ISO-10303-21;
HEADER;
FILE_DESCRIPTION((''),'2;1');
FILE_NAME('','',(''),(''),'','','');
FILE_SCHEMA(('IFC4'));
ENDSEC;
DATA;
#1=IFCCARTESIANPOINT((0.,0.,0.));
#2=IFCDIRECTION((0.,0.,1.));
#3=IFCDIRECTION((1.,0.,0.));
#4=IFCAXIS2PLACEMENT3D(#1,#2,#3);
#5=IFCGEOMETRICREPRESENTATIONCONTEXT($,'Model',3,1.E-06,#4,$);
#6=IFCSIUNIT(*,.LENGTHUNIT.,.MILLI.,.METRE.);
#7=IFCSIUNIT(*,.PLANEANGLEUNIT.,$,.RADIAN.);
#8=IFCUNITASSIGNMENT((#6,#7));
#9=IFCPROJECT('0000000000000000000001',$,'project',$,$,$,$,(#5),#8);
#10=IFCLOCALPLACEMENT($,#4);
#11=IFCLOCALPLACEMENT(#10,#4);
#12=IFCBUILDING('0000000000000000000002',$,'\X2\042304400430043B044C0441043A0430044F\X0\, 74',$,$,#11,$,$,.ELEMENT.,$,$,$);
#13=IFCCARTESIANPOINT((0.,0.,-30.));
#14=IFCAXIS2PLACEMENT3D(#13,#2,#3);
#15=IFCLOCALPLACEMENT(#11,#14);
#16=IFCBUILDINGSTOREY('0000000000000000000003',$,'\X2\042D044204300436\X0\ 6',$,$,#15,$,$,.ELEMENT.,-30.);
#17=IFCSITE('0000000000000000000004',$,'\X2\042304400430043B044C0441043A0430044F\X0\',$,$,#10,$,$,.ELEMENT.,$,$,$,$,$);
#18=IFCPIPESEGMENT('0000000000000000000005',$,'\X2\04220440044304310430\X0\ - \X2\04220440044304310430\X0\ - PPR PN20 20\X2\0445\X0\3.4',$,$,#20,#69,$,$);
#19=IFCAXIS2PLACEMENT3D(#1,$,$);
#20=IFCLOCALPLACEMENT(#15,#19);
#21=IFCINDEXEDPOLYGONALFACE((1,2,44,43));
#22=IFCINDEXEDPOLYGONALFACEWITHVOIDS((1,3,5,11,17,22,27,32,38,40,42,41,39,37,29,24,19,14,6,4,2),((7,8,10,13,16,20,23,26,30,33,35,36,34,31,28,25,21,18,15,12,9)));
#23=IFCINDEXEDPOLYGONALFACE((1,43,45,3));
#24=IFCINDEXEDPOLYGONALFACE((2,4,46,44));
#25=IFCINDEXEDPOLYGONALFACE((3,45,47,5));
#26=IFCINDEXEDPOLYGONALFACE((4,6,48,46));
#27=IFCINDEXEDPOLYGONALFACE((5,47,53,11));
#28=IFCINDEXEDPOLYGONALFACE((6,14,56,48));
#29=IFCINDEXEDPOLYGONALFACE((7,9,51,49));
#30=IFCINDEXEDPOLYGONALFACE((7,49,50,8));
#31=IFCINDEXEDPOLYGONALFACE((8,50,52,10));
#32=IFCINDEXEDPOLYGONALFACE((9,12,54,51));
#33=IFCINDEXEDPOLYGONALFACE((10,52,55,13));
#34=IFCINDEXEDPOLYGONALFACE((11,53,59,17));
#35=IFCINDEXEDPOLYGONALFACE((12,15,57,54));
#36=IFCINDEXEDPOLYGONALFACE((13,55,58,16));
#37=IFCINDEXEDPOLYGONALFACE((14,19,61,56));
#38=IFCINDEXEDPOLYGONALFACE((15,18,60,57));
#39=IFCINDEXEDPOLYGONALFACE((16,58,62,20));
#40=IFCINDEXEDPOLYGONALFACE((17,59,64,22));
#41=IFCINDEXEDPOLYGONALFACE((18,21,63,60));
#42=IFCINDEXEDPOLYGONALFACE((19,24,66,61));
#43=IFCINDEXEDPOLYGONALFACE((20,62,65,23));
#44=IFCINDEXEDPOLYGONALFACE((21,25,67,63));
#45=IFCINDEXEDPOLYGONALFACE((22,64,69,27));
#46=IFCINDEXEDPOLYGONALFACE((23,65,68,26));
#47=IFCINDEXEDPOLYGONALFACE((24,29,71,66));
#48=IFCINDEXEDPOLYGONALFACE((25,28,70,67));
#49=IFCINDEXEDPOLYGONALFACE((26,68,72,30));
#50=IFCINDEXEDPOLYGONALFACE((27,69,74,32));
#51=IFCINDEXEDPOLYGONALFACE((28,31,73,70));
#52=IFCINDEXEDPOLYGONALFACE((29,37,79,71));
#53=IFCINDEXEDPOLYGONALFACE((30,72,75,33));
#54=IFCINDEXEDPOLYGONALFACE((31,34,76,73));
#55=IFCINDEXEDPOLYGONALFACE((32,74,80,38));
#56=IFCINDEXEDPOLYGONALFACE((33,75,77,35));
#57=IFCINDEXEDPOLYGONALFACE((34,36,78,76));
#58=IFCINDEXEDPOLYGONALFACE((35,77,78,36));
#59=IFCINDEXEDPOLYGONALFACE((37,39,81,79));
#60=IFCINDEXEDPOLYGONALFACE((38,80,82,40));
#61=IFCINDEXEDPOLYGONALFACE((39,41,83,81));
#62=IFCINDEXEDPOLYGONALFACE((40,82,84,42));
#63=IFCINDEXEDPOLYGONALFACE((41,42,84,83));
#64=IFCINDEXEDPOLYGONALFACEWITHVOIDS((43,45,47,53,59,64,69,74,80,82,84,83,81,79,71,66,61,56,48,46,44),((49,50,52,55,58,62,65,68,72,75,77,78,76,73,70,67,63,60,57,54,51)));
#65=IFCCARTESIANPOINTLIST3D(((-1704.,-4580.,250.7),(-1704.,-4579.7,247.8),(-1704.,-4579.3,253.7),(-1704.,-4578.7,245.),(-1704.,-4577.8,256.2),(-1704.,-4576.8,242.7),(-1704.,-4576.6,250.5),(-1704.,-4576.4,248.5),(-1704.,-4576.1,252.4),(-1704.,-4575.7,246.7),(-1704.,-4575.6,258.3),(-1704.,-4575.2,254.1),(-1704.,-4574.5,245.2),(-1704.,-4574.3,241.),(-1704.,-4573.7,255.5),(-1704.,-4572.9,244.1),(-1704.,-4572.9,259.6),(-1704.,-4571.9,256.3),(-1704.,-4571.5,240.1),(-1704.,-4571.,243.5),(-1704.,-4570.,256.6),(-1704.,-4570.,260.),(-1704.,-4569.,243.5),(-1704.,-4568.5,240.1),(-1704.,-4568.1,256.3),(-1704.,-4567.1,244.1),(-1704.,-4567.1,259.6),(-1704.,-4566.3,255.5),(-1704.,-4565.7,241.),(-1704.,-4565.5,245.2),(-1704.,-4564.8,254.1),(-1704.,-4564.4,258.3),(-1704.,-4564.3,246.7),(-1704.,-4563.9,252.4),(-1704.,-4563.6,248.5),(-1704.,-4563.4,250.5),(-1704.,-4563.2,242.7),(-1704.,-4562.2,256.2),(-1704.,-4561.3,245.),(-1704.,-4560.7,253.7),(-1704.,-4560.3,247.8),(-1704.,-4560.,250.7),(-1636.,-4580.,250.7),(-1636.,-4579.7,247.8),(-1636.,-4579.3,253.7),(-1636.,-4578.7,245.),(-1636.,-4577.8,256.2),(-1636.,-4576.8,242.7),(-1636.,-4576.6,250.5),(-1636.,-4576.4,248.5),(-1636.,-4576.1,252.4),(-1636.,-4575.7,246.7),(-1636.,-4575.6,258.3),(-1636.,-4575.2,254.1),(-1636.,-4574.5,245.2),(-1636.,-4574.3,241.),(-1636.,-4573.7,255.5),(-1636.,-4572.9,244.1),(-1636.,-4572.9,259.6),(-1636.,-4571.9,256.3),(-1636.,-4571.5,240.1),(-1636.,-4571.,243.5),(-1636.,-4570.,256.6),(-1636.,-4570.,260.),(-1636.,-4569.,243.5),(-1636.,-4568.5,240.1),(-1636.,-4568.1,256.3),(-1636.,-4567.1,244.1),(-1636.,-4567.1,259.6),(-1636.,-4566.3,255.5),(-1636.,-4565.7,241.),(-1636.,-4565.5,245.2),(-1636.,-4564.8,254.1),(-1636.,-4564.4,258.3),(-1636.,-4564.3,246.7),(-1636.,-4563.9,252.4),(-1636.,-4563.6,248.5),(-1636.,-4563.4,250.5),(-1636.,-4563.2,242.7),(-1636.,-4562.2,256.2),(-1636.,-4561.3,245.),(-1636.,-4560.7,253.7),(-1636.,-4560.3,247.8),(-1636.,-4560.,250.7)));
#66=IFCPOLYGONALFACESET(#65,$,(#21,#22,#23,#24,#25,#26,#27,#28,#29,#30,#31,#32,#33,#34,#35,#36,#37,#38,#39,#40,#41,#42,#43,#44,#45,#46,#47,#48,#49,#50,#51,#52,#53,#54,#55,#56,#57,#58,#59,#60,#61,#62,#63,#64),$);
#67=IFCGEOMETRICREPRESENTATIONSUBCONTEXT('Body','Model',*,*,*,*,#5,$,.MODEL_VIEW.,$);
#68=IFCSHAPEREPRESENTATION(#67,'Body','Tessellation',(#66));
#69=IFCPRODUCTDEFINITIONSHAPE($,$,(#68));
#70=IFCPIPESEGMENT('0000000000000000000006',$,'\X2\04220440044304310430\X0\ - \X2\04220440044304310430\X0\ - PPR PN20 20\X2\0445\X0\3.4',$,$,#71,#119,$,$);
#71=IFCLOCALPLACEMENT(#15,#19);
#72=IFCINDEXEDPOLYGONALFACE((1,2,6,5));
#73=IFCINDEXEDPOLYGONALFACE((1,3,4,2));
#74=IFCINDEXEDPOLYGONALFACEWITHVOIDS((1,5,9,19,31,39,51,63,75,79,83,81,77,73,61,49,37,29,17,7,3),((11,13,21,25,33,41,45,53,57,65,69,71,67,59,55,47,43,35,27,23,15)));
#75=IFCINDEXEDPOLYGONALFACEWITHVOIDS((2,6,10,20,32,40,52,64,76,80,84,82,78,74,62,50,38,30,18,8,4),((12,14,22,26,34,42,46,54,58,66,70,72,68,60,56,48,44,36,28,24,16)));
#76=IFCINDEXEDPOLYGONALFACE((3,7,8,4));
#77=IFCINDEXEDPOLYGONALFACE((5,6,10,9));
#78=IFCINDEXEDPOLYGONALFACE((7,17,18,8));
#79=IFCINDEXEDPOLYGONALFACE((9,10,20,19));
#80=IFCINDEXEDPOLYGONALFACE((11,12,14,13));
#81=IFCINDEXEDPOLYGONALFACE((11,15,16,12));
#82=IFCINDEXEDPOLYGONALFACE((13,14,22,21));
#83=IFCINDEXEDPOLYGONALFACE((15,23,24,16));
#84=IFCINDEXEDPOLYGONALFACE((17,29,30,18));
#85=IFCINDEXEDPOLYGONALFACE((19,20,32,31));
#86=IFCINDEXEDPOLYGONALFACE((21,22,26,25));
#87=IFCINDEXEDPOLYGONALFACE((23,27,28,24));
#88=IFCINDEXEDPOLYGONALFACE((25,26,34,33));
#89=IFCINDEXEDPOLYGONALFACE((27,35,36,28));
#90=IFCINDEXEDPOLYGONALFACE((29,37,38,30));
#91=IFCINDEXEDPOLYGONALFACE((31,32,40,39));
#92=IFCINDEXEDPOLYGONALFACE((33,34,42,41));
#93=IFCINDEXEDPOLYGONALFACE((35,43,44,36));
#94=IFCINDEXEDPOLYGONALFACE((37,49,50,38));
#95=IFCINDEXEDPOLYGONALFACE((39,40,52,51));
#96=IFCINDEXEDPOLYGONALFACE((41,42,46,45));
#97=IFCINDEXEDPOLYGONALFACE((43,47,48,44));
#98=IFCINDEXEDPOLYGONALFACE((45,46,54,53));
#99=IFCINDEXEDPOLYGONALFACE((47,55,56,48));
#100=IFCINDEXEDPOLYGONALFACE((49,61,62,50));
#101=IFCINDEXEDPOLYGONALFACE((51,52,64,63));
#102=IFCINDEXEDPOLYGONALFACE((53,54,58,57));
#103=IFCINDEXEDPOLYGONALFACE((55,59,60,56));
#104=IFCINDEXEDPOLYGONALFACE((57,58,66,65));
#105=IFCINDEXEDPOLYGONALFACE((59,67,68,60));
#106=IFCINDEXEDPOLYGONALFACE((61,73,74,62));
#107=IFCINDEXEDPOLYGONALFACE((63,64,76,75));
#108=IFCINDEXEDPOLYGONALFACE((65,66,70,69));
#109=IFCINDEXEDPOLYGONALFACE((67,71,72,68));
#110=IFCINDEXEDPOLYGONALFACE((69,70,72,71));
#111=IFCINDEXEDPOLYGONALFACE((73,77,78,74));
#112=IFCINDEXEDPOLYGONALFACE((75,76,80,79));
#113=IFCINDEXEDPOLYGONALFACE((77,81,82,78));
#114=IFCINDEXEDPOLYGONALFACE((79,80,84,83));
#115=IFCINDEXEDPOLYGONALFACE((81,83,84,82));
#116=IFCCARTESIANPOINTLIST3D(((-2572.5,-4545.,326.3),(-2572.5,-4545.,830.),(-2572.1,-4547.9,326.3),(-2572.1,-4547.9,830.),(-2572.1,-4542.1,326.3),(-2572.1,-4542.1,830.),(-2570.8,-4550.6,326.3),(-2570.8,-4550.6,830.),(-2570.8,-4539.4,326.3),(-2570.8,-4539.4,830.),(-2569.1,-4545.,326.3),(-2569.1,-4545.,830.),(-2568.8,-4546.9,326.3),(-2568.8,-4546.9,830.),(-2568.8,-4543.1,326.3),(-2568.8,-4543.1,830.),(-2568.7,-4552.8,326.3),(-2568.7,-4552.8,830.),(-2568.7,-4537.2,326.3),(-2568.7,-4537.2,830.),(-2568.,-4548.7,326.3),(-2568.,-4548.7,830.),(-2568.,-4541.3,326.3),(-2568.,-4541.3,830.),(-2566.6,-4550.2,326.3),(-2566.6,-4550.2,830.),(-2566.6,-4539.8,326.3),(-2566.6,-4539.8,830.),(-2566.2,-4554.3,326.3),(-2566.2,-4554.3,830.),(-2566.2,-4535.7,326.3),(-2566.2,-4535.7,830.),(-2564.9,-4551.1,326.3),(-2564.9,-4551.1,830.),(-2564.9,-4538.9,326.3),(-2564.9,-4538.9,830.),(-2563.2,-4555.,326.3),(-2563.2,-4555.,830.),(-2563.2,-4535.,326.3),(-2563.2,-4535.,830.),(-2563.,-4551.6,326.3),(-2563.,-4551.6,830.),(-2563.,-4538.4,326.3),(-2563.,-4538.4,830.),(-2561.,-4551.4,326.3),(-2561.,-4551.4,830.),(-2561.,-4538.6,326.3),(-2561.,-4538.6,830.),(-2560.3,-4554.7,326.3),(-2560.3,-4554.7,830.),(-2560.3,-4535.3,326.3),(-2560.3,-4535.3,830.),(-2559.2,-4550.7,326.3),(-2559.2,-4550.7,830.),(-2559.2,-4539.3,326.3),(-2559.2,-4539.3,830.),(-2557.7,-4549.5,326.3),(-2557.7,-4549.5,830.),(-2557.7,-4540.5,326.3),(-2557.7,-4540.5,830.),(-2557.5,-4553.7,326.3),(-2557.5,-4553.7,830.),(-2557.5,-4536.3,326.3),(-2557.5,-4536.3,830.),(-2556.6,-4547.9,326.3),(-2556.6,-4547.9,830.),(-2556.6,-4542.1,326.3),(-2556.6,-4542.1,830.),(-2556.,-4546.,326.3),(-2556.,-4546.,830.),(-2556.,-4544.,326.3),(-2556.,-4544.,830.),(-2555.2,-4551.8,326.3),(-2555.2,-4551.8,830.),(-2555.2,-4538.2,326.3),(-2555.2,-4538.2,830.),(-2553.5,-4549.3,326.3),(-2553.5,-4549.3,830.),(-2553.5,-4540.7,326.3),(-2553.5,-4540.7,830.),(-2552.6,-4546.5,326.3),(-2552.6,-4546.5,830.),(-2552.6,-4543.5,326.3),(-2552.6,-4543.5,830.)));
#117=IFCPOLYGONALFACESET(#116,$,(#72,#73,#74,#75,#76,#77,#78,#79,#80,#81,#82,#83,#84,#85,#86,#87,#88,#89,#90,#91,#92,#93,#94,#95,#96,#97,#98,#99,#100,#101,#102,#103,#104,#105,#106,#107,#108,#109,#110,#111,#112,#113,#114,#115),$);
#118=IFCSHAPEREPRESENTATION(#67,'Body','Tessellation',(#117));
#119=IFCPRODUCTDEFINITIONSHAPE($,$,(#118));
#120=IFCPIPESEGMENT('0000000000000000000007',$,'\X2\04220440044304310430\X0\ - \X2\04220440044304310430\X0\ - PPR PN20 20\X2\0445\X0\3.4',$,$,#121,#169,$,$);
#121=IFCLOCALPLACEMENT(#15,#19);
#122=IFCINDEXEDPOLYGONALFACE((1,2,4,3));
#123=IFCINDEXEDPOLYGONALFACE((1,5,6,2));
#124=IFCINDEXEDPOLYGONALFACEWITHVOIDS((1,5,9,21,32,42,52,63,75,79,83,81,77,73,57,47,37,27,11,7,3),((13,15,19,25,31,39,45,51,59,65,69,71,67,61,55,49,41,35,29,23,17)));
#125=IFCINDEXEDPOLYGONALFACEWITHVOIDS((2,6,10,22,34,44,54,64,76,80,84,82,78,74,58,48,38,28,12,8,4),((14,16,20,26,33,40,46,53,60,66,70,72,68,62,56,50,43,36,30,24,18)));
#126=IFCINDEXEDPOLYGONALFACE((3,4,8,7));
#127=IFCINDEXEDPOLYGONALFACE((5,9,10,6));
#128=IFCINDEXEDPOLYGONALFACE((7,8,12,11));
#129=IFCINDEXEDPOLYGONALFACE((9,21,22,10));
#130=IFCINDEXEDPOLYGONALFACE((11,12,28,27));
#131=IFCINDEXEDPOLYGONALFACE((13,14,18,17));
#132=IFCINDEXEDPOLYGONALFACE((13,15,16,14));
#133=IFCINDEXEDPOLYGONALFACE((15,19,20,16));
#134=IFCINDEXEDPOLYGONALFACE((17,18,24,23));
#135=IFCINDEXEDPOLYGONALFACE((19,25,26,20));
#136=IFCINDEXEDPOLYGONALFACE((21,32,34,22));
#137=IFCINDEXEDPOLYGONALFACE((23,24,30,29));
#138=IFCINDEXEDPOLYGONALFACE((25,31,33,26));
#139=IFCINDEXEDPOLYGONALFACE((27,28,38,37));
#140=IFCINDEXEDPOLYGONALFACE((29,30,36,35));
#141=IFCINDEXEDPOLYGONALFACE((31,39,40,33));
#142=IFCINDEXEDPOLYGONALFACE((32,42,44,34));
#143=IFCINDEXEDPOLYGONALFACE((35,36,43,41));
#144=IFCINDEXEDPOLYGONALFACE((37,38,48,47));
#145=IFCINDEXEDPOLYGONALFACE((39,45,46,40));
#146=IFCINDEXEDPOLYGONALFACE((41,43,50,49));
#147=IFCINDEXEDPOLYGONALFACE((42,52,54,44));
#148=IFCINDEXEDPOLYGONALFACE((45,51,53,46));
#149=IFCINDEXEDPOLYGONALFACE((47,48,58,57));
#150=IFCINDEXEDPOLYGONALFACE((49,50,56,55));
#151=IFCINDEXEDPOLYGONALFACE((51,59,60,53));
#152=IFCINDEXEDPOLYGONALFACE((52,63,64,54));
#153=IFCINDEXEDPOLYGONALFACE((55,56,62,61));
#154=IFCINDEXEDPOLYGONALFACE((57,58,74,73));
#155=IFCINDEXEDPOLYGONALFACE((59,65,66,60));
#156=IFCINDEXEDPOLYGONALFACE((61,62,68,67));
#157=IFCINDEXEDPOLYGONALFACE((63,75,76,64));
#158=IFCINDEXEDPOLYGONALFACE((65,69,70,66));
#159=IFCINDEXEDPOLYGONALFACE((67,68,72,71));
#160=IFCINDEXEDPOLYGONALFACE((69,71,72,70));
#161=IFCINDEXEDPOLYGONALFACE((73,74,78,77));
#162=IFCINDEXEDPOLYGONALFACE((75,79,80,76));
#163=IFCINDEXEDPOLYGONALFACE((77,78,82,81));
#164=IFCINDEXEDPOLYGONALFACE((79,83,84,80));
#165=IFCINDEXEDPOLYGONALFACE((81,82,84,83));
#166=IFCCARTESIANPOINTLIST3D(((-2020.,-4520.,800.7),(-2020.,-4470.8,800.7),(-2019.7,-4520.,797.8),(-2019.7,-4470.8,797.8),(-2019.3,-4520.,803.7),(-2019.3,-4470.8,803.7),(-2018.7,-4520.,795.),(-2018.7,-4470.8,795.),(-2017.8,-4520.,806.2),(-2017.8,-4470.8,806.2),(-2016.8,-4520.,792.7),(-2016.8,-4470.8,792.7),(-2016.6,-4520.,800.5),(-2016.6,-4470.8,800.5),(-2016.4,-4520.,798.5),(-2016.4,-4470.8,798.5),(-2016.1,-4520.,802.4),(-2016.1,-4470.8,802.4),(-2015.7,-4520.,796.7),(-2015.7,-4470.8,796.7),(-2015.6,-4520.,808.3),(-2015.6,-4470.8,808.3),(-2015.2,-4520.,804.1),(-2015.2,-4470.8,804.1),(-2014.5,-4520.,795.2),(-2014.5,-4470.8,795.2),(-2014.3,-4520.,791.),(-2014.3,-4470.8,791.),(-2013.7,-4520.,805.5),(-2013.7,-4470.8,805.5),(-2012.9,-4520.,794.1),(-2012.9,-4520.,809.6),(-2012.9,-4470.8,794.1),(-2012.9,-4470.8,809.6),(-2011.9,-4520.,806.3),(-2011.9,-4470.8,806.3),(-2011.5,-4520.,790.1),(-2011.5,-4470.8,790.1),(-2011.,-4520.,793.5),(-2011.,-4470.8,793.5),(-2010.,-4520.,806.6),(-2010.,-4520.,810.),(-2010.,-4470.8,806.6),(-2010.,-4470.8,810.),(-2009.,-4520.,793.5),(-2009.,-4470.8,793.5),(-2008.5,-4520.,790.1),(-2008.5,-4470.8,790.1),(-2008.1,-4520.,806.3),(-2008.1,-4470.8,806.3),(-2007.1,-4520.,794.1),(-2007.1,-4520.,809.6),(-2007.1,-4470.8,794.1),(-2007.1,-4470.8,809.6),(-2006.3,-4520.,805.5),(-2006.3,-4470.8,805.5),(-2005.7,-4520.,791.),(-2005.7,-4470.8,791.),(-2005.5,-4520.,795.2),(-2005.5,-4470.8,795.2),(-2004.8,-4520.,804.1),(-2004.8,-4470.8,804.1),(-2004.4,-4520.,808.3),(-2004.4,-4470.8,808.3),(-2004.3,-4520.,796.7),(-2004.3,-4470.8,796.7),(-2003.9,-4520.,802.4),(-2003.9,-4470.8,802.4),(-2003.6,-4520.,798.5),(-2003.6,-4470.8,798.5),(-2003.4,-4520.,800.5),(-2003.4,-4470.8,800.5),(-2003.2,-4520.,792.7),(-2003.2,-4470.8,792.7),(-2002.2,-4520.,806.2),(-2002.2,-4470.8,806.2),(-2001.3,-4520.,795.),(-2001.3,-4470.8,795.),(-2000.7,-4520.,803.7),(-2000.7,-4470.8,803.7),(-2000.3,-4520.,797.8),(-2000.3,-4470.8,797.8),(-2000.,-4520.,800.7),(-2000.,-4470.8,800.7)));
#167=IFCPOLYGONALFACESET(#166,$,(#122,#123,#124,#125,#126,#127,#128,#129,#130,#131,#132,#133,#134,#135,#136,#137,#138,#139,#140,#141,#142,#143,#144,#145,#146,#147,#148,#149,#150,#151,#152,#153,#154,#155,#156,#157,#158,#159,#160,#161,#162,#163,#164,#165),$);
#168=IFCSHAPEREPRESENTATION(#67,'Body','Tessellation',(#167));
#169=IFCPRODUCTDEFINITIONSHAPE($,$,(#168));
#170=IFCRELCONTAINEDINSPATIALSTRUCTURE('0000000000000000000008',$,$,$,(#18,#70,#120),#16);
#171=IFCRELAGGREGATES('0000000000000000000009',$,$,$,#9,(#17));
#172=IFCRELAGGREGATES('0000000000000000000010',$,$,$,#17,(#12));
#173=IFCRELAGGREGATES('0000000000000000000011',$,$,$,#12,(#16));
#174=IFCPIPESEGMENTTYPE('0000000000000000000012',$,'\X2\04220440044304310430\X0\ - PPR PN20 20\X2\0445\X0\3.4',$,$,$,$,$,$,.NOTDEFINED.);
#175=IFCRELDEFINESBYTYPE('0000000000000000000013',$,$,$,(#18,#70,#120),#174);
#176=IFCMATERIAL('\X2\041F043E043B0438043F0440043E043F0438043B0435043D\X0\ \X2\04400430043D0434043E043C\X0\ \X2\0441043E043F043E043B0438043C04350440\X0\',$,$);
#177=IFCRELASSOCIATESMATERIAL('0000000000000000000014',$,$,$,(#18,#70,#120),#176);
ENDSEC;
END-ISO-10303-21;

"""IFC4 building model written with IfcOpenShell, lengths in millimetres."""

from ifc_helpers import new_model, entity, si_unit, frame, origin_with_axes, place, context, subcontext, project, spatial, material, type_object, element, save


model = new_model("IFC4")

# Units and contexts
model_context = context("Model", 3, precision=1e-06, world=origin_with_axes())
body_context = subcontext(model_context, "Body", "Model", "MODEL_VIEW")
ifc_project = project(units=[si_unit("LENGTHUNIT", "METRE", prefix="MILLI"), si_unit("PLANEANGLEUNIT", "RADIAN")], contexts=[model_context])

# Site, building, storey
site_placement = place(None, origin_with_axes())
site = spatial("IfcSite", under=ifc_project, at=site_placement, Name="Уральская", CompositionType="ELEMENT")
building_placement = place(site_placement, origin_with_axes())
building = spatial("IfcBuilding", under=site, at=building_placement, Name="Уральская, 74", CompositionType="ELEMENT")
storey_placement = place(building_placement, frame((0.0, 0.0, -30.0), z_axis=(0.0, 0.0, 1.0), x_axis=(1.0, 0.0, 0.0)))
storey = spatial("IfcBuildingStorey", under=building, at=storey_placement, Name="Этаж 6", CompositionType="ELEMENT", Elevation=-30.0)

# Pipe segments
ifc_material_1 = material(Name="Полипропилен рандом сополимер")
pipe_segment_type_1 = type_object("IfcPipeSegmentType", Name="Труба - PPR PN20 20х3.4", PredefinedType="NOTDEFINED")
pipe_segment_1_placement = place(storey_placement, frame((-1636.0, -4570.0, 250.0), z_axis=(0.0, 0.0, 1.0), x_axis=(-1.0, 0.0, 0.0)))
element("IfcPipeSegment", 1, at=pipe_segment_1_placement, inside=storey, type_object=pipe_segment_type_1, material=ifc_material_1, Name="Труба - Труба - PPR PN20 20х3.4", context=body_context, shape_type="AdvancedSweptSolid", body=[
    entity("IfcSweptDiskSolid", entity("IfcIndexedPolyCurve", entity("IfcCartesianPointList3D", [[0.0, 0.0, 0.0], [68.0, 0.0, 0.0]]), [entity("IfcLineIndex", [1, 2])]), 10.0, 6.6),
])
pipe_segment_2_placement = place(storey_placement, frame((-2562.5, -4545.0, 830.0), z_axis=(0.0, 0.0, 1.0), x_axis=(1.0, 0.0, 0.0)))
element("IfcPipeSegment", 2, at=pipe_segment_2_placement, inside=storey, type_object=pipe_segment_type_1, material=ifc_material_1, Name="Труба - Труба - PPR PN20 20х3.4", context=body_context, shape_type="AdvancedSweptSolid", body=[
    entity("IfcSweptDiskSolid", entity("IfcIndexedPolyCurve", entity("IfcCartesianPointList3D", [[0.0, 0.0, 0.0], [0.0, 0.0, -503.7]]), [entity("IfcLineIndex", [1, 2])]), 10.0, 6.6),
])
pipe_segment_3_placement = place(storey_placement, frame((-2010.0, -4520.0, 800.0), z_axis=(0.0, 0.0, 1.0), x_axis=(0.0, 1.0, 0.0)))
element("IfcPipeSegment", 3, at=pipe_segment_3_placement, inside=storey, type_object=pipe_segment_type_1, material=ifc_material_1, Name="Труба - Труба - PPR PN20 20х3.4", context=body_context, shape_type="AdvancedSweptSolid", body=[
    entity("IfcSweptDiskSolid", entity("IfcIndexedPolyCurve", entity("IfcCartesianPointList3D", [[0.0, 0.0, 0.0], [49.2, 0.0, 0.0]]), [entity("IfcLineIndex", [1, 2])]), 10.0, 6.6),
])

save(model, "model.ifc")
